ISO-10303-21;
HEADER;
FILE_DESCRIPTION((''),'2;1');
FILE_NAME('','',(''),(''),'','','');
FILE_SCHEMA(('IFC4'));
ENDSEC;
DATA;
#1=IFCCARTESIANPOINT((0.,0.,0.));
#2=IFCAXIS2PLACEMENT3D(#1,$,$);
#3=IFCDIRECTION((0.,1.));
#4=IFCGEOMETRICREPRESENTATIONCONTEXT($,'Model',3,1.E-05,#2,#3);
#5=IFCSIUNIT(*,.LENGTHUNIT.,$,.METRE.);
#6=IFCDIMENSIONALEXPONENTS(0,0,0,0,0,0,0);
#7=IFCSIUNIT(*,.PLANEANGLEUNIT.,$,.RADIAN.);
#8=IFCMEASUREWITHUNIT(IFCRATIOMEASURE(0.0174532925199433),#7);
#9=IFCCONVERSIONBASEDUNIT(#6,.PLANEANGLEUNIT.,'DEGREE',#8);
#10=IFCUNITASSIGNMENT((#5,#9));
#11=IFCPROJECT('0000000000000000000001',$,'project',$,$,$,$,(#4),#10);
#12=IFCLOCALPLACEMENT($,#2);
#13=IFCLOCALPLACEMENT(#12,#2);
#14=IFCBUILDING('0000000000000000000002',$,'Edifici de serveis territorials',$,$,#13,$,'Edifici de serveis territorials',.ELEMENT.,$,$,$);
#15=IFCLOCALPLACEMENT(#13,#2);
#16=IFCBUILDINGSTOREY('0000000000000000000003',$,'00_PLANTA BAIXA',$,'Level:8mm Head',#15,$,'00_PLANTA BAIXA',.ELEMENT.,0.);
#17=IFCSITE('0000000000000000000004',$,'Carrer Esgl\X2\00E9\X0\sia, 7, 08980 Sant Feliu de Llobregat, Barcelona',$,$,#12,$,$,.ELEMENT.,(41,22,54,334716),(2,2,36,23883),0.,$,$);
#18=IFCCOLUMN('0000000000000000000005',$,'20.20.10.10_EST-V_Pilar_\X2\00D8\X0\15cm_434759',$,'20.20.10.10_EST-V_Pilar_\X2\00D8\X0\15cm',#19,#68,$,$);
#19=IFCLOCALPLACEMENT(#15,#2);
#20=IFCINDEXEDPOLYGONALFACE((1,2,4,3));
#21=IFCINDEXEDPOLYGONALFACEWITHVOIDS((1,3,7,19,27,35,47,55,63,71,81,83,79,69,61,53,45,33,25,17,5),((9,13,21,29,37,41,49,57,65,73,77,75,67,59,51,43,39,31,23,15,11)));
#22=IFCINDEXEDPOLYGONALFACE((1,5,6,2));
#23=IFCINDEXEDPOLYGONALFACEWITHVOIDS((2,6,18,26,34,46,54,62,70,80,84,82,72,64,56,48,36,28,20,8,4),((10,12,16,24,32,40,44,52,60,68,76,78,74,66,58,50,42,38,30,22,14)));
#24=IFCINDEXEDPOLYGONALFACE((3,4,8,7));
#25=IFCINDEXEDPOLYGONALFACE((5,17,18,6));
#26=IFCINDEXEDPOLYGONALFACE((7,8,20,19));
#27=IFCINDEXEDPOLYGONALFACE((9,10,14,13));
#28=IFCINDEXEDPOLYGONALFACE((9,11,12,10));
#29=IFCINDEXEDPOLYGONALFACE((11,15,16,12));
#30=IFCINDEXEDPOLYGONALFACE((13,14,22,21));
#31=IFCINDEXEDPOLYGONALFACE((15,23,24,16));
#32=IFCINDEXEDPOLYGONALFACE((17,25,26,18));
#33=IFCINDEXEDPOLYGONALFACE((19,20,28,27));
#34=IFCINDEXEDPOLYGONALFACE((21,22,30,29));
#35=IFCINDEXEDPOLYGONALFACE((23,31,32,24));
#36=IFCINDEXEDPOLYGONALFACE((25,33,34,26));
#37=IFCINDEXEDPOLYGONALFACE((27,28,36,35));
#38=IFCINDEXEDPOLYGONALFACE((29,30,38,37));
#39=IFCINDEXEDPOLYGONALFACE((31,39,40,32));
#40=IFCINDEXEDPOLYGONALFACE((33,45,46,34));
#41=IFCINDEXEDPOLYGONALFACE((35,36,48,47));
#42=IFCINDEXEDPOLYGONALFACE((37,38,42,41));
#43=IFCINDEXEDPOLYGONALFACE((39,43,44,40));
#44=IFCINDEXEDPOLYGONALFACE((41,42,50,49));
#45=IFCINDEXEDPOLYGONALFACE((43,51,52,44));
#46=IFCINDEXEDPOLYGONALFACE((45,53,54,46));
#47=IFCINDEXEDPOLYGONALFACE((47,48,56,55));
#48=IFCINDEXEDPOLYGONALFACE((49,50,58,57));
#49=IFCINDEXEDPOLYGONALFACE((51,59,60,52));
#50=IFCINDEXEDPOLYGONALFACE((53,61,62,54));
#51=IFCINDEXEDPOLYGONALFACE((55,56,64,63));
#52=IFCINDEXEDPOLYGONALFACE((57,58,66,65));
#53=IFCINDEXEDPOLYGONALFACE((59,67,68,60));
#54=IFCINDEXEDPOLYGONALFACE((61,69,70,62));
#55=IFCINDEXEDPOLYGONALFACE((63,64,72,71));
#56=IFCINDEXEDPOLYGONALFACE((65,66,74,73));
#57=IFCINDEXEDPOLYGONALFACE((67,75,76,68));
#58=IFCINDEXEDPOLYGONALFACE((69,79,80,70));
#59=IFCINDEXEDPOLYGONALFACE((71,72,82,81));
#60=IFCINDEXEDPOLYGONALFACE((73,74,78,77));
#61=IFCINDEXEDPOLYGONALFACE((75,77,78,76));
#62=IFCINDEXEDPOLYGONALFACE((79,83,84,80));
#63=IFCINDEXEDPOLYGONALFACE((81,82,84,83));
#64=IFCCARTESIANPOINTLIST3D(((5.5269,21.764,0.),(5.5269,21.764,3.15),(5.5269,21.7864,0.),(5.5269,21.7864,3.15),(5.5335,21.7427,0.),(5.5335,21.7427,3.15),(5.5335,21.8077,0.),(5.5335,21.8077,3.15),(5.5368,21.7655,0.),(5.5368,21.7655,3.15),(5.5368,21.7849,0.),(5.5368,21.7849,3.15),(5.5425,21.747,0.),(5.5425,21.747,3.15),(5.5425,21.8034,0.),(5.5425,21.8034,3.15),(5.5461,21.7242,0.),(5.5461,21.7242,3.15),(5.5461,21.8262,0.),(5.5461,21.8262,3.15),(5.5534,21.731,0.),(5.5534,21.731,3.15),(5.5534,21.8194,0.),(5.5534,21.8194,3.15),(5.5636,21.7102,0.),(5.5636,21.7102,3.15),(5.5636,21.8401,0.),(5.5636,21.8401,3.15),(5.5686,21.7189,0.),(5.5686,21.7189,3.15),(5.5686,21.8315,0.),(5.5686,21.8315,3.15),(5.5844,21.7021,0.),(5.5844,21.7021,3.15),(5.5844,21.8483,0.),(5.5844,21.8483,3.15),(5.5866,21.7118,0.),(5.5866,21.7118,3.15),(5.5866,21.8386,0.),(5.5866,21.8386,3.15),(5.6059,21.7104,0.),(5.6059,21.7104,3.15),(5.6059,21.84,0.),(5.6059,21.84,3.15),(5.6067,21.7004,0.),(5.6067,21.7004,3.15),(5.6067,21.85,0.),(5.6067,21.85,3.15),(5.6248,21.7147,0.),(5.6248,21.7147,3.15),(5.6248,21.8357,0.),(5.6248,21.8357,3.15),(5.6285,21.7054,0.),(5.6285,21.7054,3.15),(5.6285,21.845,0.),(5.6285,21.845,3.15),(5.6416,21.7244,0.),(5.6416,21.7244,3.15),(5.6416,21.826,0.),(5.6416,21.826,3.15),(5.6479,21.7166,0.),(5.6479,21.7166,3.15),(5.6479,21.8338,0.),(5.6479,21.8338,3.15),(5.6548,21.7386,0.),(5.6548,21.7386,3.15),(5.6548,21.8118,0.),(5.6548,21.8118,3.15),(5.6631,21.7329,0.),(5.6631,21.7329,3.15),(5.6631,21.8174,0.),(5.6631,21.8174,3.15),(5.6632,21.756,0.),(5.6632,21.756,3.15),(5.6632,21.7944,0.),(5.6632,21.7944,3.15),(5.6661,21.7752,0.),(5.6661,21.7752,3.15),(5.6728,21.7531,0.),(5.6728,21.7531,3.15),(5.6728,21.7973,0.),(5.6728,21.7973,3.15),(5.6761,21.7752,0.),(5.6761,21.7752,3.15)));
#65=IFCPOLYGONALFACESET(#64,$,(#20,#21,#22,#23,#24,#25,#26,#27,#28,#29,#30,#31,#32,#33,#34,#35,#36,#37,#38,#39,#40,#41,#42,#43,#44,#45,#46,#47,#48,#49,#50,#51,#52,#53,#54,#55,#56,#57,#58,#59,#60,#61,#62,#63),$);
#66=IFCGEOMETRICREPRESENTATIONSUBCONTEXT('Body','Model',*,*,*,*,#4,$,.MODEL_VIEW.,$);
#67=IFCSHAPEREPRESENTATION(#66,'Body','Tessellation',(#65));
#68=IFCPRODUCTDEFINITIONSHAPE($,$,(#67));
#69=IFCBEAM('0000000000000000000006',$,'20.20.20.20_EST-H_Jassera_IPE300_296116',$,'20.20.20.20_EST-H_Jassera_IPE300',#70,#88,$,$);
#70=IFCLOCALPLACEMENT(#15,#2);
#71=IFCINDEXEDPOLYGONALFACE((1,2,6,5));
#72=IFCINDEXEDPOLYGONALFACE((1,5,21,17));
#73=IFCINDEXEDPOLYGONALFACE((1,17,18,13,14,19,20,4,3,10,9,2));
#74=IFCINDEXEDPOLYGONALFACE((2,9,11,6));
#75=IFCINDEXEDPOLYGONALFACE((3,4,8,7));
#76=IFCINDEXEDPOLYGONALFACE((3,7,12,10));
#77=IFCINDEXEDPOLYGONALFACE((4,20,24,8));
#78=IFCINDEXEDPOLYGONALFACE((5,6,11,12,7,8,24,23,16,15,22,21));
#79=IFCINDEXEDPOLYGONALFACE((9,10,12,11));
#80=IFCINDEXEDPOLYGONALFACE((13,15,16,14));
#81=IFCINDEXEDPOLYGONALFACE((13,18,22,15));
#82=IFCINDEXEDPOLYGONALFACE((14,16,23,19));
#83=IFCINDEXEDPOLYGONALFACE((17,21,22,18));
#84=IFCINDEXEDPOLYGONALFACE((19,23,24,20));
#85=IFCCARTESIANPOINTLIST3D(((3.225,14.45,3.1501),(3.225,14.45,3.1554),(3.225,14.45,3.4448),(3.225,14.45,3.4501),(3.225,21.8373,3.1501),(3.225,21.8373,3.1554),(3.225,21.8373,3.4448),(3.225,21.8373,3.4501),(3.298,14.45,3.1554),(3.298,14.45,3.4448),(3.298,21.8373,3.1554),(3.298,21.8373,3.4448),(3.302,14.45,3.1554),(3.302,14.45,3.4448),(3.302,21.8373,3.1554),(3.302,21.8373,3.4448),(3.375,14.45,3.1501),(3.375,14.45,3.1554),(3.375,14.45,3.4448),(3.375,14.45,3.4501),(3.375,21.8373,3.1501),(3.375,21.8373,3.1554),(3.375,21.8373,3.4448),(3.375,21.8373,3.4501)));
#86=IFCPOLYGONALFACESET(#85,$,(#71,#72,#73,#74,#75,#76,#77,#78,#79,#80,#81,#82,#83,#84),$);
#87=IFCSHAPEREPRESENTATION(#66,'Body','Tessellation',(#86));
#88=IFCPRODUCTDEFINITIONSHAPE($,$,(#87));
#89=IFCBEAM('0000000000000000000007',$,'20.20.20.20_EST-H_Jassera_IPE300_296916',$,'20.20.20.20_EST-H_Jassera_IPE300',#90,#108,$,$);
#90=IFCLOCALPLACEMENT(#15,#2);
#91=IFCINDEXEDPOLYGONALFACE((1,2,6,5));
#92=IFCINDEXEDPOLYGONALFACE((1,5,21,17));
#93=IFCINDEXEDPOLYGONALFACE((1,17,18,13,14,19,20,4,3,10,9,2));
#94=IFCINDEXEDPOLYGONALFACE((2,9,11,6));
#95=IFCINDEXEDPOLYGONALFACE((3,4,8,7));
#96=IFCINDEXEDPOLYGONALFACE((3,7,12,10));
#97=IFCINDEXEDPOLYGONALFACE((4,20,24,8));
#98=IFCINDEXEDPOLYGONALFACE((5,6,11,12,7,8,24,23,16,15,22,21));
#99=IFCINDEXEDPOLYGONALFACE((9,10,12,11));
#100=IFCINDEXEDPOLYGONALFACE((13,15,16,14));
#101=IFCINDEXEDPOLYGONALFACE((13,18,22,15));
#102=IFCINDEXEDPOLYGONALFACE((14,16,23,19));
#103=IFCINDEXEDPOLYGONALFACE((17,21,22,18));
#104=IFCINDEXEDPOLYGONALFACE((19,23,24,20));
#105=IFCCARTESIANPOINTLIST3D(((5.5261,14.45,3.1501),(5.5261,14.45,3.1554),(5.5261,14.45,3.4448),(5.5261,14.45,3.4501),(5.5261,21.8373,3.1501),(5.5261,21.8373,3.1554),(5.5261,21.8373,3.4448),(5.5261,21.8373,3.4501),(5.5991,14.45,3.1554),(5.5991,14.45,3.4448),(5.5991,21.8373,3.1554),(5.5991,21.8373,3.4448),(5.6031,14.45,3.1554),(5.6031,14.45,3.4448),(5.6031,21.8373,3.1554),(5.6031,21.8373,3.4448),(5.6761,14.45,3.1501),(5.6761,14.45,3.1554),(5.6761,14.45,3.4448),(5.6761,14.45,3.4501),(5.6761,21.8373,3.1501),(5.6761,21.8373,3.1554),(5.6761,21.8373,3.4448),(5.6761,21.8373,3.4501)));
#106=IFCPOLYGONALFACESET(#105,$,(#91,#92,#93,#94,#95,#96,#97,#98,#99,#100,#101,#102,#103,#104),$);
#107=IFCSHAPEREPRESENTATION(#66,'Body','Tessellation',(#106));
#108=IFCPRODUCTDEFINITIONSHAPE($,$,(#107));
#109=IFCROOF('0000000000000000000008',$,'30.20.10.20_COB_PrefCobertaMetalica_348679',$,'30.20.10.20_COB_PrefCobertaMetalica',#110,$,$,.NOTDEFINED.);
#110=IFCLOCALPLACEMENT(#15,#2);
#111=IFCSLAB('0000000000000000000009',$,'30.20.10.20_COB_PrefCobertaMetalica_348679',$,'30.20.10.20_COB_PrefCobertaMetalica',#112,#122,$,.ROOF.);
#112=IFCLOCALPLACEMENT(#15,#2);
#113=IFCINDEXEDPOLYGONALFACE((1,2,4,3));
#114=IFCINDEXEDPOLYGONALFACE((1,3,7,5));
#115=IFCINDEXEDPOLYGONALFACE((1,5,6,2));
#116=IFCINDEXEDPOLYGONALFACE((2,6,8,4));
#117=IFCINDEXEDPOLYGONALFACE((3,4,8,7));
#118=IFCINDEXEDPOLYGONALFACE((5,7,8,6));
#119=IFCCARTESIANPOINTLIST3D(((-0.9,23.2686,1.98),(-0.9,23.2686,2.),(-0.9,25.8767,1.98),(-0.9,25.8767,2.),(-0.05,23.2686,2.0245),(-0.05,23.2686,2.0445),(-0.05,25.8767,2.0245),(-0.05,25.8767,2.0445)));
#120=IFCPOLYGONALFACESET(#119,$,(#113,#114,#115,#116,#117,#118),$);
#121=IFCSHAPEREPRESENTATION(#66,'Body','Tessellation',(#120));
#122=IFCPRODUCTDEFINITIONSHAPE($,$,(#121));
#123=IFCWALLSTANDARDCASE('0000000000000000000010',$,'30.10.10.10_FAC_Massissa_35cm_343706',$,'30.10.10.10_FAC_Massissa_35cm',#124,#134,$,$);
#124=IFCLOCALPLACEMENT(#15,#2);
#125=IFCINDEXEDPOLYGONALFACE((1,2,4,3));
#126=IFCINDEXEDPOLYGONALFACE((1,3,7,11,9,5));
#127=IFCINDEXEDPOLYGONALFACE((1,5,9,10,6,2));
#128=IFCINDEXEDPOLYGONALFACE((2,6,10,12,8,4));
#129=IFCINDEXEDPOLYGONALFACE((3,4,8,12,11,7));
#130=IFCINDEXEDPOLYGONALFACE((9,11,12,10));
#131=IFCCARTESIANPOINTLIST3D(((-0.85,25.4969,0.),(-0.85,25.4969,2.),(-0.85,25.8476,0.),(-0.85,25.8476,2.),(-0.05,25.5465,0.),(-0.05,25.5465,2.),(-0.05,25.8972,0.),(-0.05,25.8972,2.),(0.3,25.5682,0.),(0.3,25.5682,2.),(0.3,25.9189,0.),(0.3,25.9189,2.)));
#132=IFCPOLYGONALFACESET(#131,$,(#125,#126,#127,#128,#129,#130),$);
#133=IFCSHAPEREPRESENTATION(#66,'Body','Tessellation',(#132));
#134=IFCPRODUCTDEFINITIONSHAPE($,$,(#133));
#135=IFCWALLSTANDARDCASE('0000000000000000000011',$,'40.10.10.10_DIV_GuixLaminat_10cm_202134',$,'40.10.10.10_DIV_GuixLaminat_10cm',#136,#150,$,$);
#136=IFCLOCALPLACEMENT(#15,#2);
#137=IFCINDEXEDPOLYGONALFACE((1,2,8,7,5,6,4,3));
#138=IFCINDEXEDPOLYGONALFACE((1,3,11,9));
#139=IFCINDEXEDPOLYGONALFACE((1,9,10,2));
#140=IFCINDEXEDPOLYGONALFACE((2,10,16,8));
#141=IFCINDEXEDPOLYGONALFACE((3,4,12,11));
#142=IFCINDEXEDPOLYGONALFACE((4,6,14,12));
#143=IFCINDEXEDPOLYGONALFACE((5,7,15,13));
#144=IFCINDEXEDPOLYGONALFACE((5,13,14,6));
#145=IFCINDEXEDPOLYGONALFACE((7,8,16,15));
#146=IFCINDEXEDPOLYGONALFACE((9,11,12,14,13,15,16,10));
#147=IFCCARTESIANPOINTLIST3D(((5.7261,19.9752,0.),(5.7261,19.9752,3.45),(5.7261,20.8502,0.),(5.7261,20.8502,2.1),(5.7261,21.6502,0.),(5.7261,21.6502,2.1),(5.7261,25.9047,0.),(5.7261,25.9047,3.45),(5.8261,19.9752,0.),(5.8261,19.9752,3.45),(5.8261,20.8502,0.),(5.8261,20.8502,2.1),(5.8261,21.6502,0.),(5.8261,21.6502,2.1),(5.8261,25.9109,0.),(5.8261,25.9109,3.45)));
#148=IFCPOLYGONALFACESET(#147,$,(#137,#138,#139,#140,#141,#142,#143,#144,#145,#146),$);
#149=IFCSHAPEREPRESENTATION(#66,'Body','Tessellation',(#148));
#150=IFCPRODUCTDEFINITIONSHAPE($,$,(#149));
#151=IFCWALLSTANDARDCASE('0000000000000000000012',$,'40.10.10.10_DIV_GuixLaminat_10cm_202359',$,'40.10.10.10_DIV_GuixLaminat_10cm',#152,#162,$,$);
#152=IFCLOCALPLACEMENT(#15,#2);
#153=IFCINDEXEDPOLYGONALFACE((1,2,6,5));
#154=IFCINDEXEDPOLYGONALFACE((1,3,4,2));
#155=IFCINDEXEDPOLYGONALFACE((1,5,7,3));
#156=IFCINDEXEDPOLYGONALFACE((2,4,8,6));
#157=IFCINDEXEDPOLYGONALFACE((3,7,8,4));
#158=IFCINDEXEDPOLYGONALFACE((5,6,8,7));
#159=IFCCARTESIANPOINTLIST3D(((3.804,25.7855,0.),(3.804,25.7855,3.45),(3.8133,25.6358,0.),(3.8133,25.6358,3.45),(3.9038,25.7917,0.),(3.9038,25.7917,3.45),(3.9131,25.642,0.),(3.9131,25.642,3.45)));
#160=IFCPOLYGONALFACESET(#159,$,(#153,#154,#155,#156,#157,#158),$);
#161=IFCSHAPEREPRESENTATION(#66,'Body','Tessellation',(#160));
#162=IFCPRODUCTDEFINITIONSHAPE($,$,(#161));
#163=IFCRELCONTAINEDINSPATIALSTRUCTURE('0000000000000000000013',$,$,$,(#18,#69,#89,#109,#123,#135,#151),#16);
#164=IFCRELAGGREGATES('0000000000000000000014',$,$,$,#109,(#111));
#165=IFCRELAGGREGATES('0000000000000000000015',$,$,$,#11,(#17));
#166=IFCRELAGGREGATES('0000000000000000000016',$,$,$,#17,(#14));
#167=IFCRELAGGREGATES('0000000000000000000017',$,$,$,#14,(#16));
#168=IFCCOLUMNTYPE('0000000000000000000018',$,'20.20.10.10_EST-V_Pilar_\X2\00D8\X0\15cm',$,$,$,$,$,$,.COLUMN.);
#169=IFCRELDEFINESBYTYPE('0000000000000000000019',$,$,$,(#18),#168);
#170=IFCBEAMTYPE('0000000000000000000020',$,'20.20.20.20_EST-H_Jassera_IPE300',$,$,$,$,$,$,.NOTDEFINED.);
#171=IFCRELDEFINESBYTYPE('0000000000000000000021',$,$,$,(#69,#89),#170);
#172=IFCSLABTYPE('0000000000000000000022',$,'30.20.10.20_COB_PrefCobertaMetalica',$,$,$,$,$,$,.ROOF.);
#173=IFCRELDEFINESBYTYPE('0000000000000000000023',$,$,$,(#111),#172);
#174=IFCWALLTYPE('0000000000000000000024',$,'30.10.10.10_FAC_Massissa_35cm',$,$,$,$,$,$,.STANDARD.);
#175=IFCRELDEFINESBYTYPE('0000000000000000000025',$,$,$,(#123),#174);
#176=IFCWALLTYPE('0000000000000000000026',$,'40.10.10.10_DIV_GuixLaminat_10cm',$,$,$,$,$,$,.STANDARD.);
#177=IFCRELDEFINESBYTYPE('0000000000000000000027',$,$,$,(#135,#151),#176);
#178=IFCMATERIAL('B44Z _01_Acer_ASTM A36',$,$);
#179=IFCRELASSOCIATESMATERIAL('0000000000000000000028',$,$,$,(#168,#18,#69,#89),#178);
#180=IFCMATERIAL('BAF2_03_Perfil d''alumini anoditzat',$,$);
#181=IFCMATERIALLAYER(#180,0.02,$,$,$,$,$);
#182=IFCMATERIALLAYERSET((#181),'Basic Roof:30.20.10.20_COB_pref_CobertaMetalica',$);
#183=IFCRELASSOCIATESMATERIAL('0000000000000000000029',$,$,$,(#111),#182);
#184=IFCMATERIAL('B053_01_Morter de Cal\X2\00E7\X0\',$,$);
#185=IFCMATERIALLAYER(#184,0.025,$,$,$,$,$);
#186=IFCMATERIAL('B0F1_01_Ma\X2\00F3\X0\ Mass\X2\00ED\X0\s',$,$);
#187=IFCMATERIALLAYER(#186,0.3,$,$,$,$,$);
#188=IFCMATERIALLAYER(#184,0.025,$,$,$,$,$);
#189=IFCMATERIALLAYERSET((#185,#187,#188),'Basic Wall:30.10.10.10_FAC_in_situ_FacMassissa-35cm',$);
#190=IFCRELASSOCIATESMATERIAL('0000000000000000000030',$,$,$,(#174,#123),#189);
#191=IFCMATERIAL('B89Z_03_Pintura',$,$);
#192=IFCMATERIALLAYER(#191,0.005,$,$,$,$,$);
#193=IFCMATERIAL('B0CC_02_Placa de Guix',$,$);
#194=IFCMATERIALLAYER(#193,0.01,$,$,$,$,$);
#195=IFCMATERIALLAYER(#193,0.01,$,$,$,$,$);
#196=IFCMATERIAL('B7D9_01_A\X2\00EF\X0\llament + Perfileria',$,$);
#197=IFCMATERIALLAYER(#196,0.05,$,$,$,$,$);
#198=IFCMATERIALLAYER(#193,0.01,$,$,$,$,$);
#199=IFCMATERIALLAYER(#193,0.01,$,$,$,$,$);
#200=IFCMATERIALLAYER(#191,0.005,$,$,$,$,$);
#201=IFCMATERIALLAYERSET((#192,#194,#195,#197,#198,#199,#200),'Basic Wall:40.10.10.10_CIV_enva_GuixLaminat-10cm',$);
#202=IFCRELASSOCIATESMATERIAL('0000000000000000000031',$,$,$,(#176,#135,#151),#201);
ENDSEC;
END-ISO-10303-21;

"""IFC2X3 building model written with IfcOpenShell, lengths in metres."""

from ifc_helpers import new_model, entity, si_unit, converted_unit, direction, frame, frame_2d, origin, place, context, subcontext, project, spatial, polyline, rectangle, hollow_circle, i_section, outline, extrude, clip, bounded_halfspace, source, transform, mapped, material, layer, layer_set, layer_usage, type_object, type_shapes, element, aggregate, save


model = new_model("IFC2X3")

# Units and contexts
model_context = context("Model", 3, precision=1e-05, world=origin(), true_north=direction((0.0, 1.0)))
body_context = subcontext(model_context, "Body", "Model", "MODEL_VIEW")
ifc_project = project(units=[si_unit("LENGTHUNIT", "METRE"), converted_unit("PLANEANGLEUNIT", "DEGREE", entity("IfcRatioMeasure", 0.0174532925199433), si_unit("PLANEANGLEUNIT", "RADIAN"), dimensions=[0, 0, 0, 0, 0, 0, 0])], contexts=[model_context])

# Site, building, storey
site_placement = place(None, origin())
site = spatial("IfcSite", under=ifc_project, at=site_placement, Name="Carrer Església, 7, 08980 Sant Feliu de Llobregat, Barcelona", CompositionType="ELEMENT", RefLatitude=(41, 22, 54, 334716), RefLongitude=(2, 2, 36, 23883), RefElevation=0.0)
building_placement = place(site_placement, origin())
building = spatial("IfcBuilding", under=site, at=building_placement, Name="Edifici de serveis territorials", LongName="Edifici de serveis territorials", CompositionType="ELEMENT")
storey_placement = place(building_placement, origin())
storey = spatial("IfcBuildingStorey", under=building, at=storey_placement, Name="00_PLANTA BAIXA", ObjectType="Level:8mm Head", LongName="00_PLANTA BAIXA", CompositionType="ELEMENT", Elevation=0.0)

# Column
ifc_material_1 = material(Name="B44Z _01_Acer_ASTM A36")
column_type = type_object("IfcColumnType", Name="20.20.10.10_EST-V_Pilar_Ø15cm", PredefinedType="COLUMN", material=ifc_material_1)
shared_shape = source(origin(), body_context, "Body", "SweptSolid", [
    extrude(hollow_circle(Radius=0.075, WallThickness=0.01, at=frame_2d((0.0, 0.0), x_axis=(1.0, 0.0))), origin(), (0.0, 0.0, 1.0), 3.15),
])
type_shapes(column_type, [shared_shape])
column_placement = place(storey_placement, frame((5.6011, 21.7752, 0.0)))
element("IfcColumn", 1, at=column_placement, inside=storey, type_object=column_type, material=ifc_material_1, Name="20.20.10.10_EST-V_Pilar_Ø15cm_434759", ObjectType="20.20.10.10_EST-V_Pilar_Ø15cm", context=body_context, shape_type="MappedRepresentation", body=[
    mapped(shared_shape, transform((0.0, 0.0, 0.0), scale=1.0)),
])

# Beams
beam_type = type_object("IfcBeamType", Name="20.20.20.20_EST-H_Jassera_IPE300", PredefinedType="NOTDEFINED")
beam_1_placement = place(storey_placement, frame((3.3, 21.85, 0.0), z_axis=(0.0, 0.0, 1.0), x_axis=(0.0, -1.0, 0.0)))
element("IfcBeam", 2, at=beam_1_placement, inside=storey, type_object=beam_type, material=ifc_material_1, Name="20.20.20.20_EST-H_Jassera_IPE300_296116", ObjectType="20.20.20.20_EST-H_Jassera_IPE300", context=body_context, shape_type="SweptSolid", body=[
    extrude(i_section(OverallWidth=0.15, OverallDepth=0.3, WebThickness=0.0041, FlangeThickness=0.0053, at=frame_2d((0.0, 0.0), x_axis=(0.0, 1.0))), frame((0.0127, 0.0, 3.3001), z_axis=(1.0, 0.0, 0.0), x_axis=(0.0, 0.0, -1.0)), (0.0, 0.0, 1.0), 7.3873),
])
beam_2_placement = place(storey_placement, frame((5.6011, 21.85, 0.0), z_axis=(0.0, 0.0, 1.0), x_axis=(0.0, -1.0, 0.0)))
element("IfcBeam", 3, at=beam_2_placement, inside=storey, type_object=beam_type, material=ifc_material_1, Name="20.20.20.20_EST-H_Jassera_IPE300_296916", ObjectType="20.20.20.20_EST-H_Jassera_IPE300", context=body_context, shape_type="SweptSolid", body=[
    extrude(i_section(OverallWidth=0.15, OverallDepth=0.3, WebThickness=0.0041, FlangeThickness=0.0053, at=frame_2d((0.0, 0.0), x_axis=(0.0, 1.0))), frame((0.0127, 0.0, 3.3001), z_axis=(1.0, 0.0, 0.0), x_axis=(0.0, 0.0, -1.0)), (0.0, 0.0, 1.0), 7.3873),
])

# Roof, slab
roof_placement = place(storey_placement, frame((-0.9, 23.2686, 1.98)))
roof = element("IfcRoof", 4, at=roof_placement, inside=storey, Name="30.20.10.20_COB_PrefCobertaMetalica_348679", ObjectType="30.20.10.20_COB_PrefCobertaMetalica", ShapeType="NOTDEFINED")
ifc_material_2 = material(Name="BAF2_03_Perfil d'alumini anoditzat")
ifc_layer_1 = layer(ifc_material_2, 0.02)
ifc_layer_set_1 = layer_set([ifc_layer_1], Name="Basic Roof:30.20.10.20_COB_pref_CobertaMetalica")
slab_type = type_object("IfcSlabType", Name="30.20.10.20_COB_PrefCobertaMetalica", PredefinedType="ROOF")
slab_placement = place(roof_placement, origin())
slab = element("IfcSlab", 5, at=slab_placement, type_object=slab_type, material=ifc_layer_set_1, Name="30.20.10.20_COB_PrefCobertaMetalica_348679", ObjectType="30.20.10.20_COB_PrefCobertaMetalica", PredefinedType="ROOF", context=body_context, shape_type="SweptSolid", body=[
    extrude(rectangle(XDim=0.8512, YDim=2.6081, at=frame_2d((0.0, 0.0), x_axis=(1.0, 0.0))), frame((0.425, 1.304, 0.0223), z_axis=(-0.052336, 0.0, 0.99863), x_axis=(0.99863, 0.0, 0.052336)), (0.052336, 0.0, 0.99863), 0.02),
])
aggregate(roof, [slab])

# Wall
ifc_material_3 = material(Name="B053_01_Morter de Calç")
ifc_layer_2 = layer(ifc_material_3, 0.025)
ifc_material_4 = material(Name="B0F1_01_Maó Massís")
ifc_layer_3 = layer(ifc_material_4, 0.3)
ifc_layer_4 = layer(ifc_material_3, 0.025)
ifc_layer_set_2 = layer_set([ifc_layer_2, ifc_layer_3, ifc_layer_4], Name="Basic Wall:30.10.10.10_FAC_in_situ_FacMassissa-35cm")
ifc_layer_usage_1 = layer_usage(ifc_layer_set_2, "AXIS2", "POSITIVE", -0.175)
wall_type_1 = type_object("IfcWallType", Name="30.10.10.10_FAC_Massissa_35cm", PredefinedType="STANDARD", material=ifc_layer_set_2)
wall_1_placement = place(storey_placement, frame((0.3108, 25.7442, 0.0), z_axis=(0.0, 0.0, 1.0), x_axis=(-0.998083, -0.061896, 0.0)))
element("IfcWallStandardCase", 6, at=wall_1_placement, inside=storey, type_object=wall_type_1, material=ifc_layer_usage_1, Name="30.10.10.10_FAC_Massissa_35cm_343706", ObjectType="30.10.10.10_FAC_Massissa_35cm", context=body_context, shape_type="SweptSolid", body=[
    extrude(outline(polyline([(1.1522, -0.175), (1.1739, 0.175), (0.3724, 0.175), (0.0217, 0.175), (0.0, -0.175), (0.3507, -0.175), (1.1522, -0.175)])), origin(), (0.0, 0.0, 1.0), 2.0),
])

# Wall, openings
ifc_material_5 = material(Name="B89Z_03_Pintura")
ifc_layer_5 = layer(ifc_material_5, 0.005)
ifc_material_6 = material(Name="B0CC_02_Placa de Guix")
ifc_layer_6 = layer(ifc_material_6, 0.01)
ifc_layer_7 = layer(ifc_material_6, 0.01)
ifc_material_7 = material(Name="B7D9_01_Aïllament + Perfileria")
ifc_layer_8 = layer(ifc_material_7, 0.05)
ifc_layer_9 = layer(ifc_material_6, 0.01)
ifc_layer_10 = layer(ifc_material_6, 0.01)
ifc_layer_11 = layer(ifc_material_5, 0.005)
ifc_layer_set_3 = layer_set([ifc_layer_5, ifc_layer_6, ifc_layer_7, ifc_layer_8, ifc_layer_9, ifc_layer_10, ifc_layer_11], Name="Basic Wall:40.10.10.10_CIV_enva_GuixLaminat-10cm")
ifc_layer_usage_2 = layer_usage(ifc_layer_set_3, "AXIS2", "NEGATIVE", 0.05)
wall_type_2 = type_object("IfcWallType", Name="40.10.10.10_DIV_GuixLaminat_10cm", PredefinedType="STANDARD", material=ifc_layer_set_3)
wall_2_placement = place(storey_placement, frame((5.7761, 25.9109, 0.0), z_axis=(0.0, 0.0, 1.0), x_axis=(0.0, -1.0, 0.0)))
wall_2 = element("IfcWallStandardCase", 7, at=wall_2_placement, inside=storey, type_object=wall_type_2, material=ifc_layer_usage_2, Name="40.10.10.10_DIV_GuixLaminat_10cm_202134", ObjectType="40.10.10.10_DIV_GuixLaminat_10cm", context=body_context, shape_type="Clipping", body=[
    clip(extrude(outline(polyline([(0.0062, -0.05), (0.0563, -0.05), (0.1565, -0.05), (5.9357, -0.05), (5.9357, -0.025), (5.9357, 0.05), (0.0, 0.05), (0.0047, -0.025), (0.0062, -0.05)])), origin(), (0.0, 0.0, 1.0), 3.45), bounded_halfspace(frame((0.0062, -0.05, 3.45), z_axis=(0.0, 0.0, -1.0), x_axis=(0.999675, 0.025497, 0.0)), True, frame((0.0062, -0.05, 3.45)), polyline([(0.0, 0.0), (0.0501, 0.0), (0.1503, 0.0), (5.9295, 0.0), (5.9295, 0.025), (5.9295, 0.1), (-0.0062, 0.1), (-0.0016, 0.025), (0.0, 0.0)]))),
])
opening_1_placement = place(wall_2_placement, frame((3.9759, -0.05, 0.0)))
element("IfcOpeningElement", 8, at=opening_1_placement, cuts=wall_2, ObjectType="Opening", context=body_context, shape_type="SweptSolid", body=[
    extrude(rectangle(XDim=2.1, YDim=0.8, at=frame_2d((1.05, 0.4), x_axis=(1.0, 0.0))), frame((0.0, 0.0, 0.0), z_axis=(0.0, -1.0, 0.0), x_axis=(0.0, 0.0, 1.0)), (0.0, 0.0, 1.0), 0.1),
])
opening_2_placement = place(wall_2_placement, frame((5.0607, 0.05, 0.0)))
element("IfcOpeningElement", 9, at=opening_2_placement, cuts=wall_2, ObjectType="Opening", context=body_context, shape_type="SweptSolid", body=[
    extrude(rectangle(XDim=2.1, YDim=0.8, at=frame_2d((1.05, 0.4), x_axis=(1.0, 0.0))), frame((0.0, 0.0, 0.0), z_axis=(0.0, -1.0, 0.0), x_axis=(0.0, 0.0, 1.0)), (0.0, 0.0, 1.0), 0.1),
])

# Wall
ifc_layer_usage_3 = layer_usage(ifc_layer_set_3, "AXIS2", "NEGATIVE", 0.05)
wall_3_placement = place(storey_placement, frame((3.8539, 25.7886, 0.0), z_axis=(0.0, 0.0, 1.0), x_axis=(0.061896, -0.998083, 0.0)))
element("IfcWallStandardCase", 10, at=wall_3_placement, inside=storey, type_object=wall_type_2, material=ifc_layer_usage_3, Name="40.10.10.10_DIV_GuixLaminat_10cm_202359", ObjectType="40.10.10.10_DIV_GuixLaminat_10cm", context=body_context, shape_type="Clipping", body=[
    clip(extrude(rectangle(XDim=0.15, YDim=0.1, at=frame_2d((0.075, 0.0), x_axis=(-1.0, 0.0))), origin(), (0.0, 0.0, 1.0), 3.45), bounded_halfspace(frame((0.0, -0.05, 3.45), z_axis=(0.0, 0.0, -1.0), x_axis=(0.999336, -0.036428, 0.0)), True, frame((0.0, -0.05, 3.45)), polyline([(0.0, 0.0), (0.05, 0.0), (0.15, 0.0), (0.15, 0.1), (0.0, 0.1), (0.0, 0.0)]))),
])

save(model, "model.ifc")
